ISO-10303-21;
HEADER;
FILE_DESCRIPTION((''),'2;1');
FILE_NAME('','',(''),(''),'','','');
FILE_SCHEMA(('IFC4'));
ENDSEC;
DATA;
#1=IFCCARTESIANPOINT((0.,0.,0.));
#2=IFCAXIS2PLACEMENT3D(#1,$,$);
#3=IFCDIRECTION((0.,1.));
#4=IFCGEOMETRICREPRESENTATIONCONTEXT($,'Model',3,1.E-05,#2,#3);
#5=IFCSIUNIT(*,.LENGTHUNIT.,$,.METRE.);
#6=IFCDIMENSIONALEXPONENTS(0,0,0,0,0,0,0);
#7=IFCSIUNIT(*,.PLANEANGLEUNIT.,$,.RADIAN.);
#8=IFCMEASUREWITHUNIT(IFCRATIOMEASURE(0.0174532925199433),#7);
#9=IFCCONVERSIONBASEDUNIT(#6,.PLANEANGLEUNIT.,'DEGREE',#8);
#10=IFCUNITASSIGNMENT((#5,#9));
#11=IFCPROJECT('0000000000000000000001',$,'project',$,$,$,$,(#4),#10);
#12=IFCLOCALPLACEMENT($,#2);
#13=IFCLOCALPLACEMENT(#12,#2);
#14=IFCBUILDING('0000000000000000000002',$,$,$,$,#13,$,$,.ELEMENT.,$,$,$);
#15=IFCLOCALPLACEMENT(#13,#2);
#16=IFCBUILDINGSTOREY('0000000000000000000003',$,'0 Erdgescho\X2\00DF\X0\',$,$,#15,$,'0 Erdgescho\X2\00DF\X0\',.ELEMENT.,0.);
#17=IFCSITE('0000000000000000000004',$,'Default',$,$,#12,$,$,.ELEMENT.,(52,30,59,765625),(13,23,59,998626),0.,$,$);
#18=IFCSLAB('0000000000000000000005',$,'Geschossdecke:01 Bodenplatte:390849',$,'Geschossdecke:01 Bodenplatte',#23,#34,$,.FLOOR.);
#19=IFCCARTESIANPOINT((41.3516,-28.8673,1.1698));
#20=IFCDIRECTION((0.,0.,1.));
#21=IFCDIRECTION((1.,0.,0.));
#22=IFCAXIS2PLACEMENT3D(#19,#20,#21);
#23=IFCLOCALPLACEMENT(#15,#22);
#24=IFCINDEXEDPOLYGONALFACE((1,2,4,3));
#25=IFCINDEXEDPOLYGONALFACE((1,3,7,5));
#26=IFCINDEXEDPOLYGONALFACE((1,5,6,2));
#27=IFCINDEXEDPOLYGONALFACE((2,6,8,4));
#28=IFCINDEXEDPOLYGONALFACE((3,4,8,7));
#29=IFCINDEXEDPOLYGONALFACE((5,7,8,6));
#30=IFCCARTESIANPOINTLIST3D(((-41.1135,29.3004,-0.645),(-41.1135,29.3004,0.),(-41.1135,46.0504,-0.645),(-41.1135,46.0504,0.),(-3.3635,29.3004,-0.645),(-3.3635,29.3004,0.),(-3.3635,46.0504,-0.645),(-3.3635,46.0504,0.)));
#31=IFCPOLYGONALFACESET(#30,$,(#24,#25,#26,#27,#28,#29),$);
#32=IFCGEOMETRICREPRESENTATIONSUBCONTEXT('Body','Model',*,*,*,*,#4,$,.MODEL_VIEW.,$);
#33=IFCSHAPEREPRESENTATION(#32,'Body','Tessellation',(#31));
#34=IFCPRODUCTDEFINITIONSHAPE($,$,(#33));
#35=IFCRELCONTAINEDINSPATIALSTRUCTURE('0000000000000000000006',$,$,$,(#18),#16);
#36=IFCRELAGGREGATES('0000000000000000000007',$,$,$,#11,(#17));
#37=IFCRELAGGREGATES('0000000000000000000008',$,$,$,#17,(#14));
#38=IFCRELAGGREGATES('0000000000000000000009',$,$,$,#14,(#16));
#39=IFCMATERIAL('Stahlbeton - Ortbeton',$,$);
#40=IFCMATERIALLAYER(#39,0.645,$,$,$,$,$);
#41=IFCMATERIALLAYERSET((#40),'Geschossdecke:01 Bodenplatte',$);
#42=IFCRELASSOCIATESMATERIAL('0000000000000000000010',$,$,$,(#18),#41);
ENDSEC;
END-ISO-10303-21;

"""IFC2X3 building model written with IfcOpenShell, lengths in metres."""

from ifc_helpers import new_model, entity, si_unit, converted_unit, direction, frame, frame_2d, origin, place, context, subcontext, project, spatial, rectangle, extrude, material, layer, layer_set, layer_usage, element, save


model = new_model("IFC2X3")

# Units and contexts
model_context = context("Model", 3, precision=1e-05, world=origin(), true_north=direction((0.0, 1.0)))
body_context = subcontext(model_context, "Body", "Model", "MODEL_VIEW")
ifc_project = project(units=[si_unit("LENGTHUNIT", "METRE"), converted_unit("PLANEANGLEUNIT", "DEGREE", entity("IfcRatioMeasure", 0.0174532925199433), si_unit("PLANEANGLEUNIT", "RADIAN"), dimensions=[0, 0, 0, 0, 0, 0, 0])], contexts=[model_context])

# Site, building, storey
site_placement = place(None, origin())
site = spatial("IfcSite", under=ifc_project, at=site_placement, Name="Default", CompositionType="ELEMENT", RefLatitude=(52, 30, 59, 765625), RefLongitude=(13, 23, 59, 998626), RefElevation=0.0)
building_placement = place(site_placement, origin())
building = spatial("IfcBuilding", under=site, at=building_placement, CompositionType="ELEMENT")
storey_placement = place(building_placement, origin())
storey = spatial("IfcBuildingStorey", under=building, at=storey_placement, Name="0 Erdgeschoß", LongName="0 Erdgeschoß", CompositionType="ELEMENT", Elevation=0.0)

# Slab
ifc_material_1 = material(Name="Stahlbeton - Ortbeton")
ifc_layer_1 = layer(ifc_material_1, 0.645)
ifc_layer_set_1 = layer_set([ifc_layer_1], Name="Geschossdecke:01 Bodenplatte")
ifc_layer_usage_1 = layer_usage(ifc_layer_set_1, "AXIS3", "POSITIVE", 0.0)
slab_placement = place(storey_placement, frame((41.3516, -28.8673, 1.1698), z_axis=(0.0, 0.0, 1.0), x_axis=(1.0, 0.0, 0.0)))
element("IfcSlab", 1, at=slab_placement, inside=storey, material=ifc_layer_usage_1, Name="Geschossdecke:01 Bodenplatte:390849", ObjectType="Geschossdecke:01 Bodenplatte", PredefinedType="FLOOR", context=body_context, shape_type="SweptSolid", body=[
    extrude(rectangle(XDim=16.75, YDim=37.75, at=frame_2d((0.0, 0.0), x_axis=(1.0, 0.0))), frame((-22.2385, 37.6754, 0.0), z_axis=(0.0, 0.0, -1.0), x_axis=(0.0, 1.0, 0.0)), (0.0, 0.0, 1.0), 0.645),
])

save(model, "model.ifc")
